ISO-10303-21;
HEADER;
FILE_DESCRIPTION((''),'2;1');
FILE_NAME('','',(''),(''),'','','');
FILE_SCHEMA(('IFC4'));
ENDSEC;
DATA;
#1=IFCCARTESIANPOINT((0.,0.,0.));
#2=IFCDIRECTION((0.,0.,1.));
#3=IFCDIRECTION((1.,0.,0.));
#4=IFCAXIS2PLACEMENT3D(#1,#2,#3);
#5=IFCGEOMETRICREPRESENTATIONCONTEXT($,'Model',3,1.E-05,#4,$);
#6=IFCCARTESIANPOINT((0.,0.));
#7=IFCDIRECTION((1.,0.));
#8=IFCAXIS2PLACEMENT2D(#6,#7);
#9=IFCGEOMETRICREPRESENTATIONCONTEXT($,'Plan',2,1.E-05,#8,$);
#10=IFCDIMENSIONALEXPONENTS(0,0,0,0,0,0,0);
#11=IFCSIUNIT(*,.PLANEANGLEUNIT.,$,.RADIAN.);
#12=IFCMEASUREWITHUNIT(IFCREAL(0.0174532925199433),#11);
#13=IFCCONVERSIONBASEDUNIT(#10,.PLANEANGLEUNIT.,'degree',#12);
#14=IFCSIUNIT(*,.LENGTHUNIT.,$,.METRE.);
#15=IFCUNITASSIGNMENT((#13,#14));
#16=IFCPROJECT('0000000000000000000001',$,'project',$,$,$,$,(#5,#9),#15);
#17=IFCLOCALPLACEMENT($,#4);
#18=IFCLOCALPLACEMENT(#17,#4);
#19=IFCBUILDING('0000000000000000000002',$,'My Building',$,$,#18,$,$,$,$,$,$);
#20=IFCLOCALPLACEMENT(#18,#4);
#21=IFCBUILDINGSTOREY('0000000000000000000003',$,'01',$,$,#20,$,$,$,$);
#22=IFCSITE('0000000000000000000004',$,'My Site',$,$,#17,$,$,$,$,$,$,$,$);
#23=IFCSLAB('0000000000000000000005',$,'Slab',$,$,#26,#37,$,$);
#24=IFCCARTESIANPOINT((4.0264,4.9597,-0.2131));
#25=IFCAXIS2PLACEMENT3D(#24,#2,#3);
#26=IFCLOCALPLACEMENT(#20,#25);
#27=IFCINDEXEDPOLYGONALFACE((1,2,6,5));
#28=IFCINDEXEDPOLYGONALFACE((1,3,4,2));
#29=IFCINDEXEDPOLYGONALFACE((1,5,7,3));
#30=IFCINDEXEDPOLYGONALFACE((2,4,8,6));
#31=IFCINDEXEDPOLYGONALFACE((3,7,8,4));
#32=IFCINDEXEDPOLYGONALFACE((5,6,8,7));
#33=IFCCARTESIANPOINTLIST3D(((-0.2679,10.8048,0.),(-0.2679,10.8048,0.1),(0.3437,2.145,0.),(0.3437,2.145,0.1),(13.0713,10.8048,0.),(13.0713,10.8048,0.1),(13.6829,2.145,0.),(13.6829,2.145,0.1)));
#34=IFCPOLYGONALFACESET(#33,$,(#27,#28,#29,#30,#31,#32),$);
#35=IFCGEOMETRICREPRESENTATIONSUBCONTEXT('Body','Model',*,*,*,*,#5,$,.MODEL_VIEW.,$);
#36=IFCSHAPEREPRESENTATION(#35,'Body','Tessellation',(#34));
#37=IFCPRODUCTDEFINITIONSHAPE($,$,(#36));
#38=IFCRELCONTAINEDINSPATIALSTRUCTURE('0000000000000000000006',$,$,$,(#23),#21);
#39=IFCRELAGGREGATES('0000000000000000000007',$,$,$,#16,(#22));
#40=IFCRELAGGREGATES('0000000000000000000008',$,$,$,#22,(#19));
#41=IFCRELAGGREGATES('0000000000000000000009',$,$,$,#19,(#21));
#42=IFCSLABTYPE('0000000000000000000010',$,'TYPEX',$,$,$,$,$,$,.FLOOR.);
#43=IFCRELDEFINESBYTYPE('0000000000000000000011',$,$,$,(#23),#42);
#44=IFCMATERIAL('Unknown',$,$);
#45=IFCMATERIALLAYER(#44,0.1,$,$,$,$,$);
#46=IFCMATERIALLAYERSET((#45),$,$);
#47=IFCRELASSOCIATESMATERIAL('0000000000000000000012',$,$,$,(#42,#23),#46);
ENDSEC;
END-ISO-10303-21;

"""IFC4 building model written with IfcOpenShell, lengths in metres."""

from ifc_helpers import new_model, entity, si_unit, converted_unit, frame, origin_with_axes, origin_2d_with_axis, place, context, subcontext, project, spatial, line, indexed_curve, outline, extrude, material, layer, layer_set, layer_usage, type_object, element, save


model = new_model("IFC4")

# Units and contexts
model_context = context("Model", 3, precision=1e-05, world=origin_with_axes())
plan_context = context("Plan", 2, precision=1e-05, world=origin_2d_with_axis())
body_context = subcontext(model_context, "Body", "Model", "MODEL_VIEW")
ifc_project = project(units=[converted_unit("PLANEANGLEUNIT", "degree", entity("IfcReal", 0.0174532925199433), si_unit("PLANEANGLEUNIT", "RADIAN"), dimensions=[0, 0, 0, 0, 0, 0, 0]), si_unit("LENGTHUNIT", "METRE")], contexts=[model_context, plan_context])

# Site, building, storey
site_placement = place(None, origin_with_axes())
site = spatial("IfcSite", under=ifc_project, at=site_placement, Name="My Site")
building_placement = place(site_placement, origin_with_axes())
building = spatial("IfcBuilding", under=site, at=building_placement, Name="My Building")
storey_placement = place(building_placement, origin_with_axes())
storey = spatial("IfcBuildingStorey", under=building, at=storey_placement, Name="01")

# Slab
ifc_material = material(Name="Unknown")
ifc_layer_1 = layer(ifc_material, 0.1)
ifc_layer_set_1 = layer_set([ifc_layer_1])
ifc_layer_usage_1 = layer_usage(ifc_layer_set_1, "AXIS3", "POSITIVE", 0.0)
slab_type = type_object("IfcSlabType", Name="TYPEX", PredefinedType="FLOOR", material=ifc_layer_set_1)
slab_placement = place(storey_placement, frame((4.0264, 4.9597, -0.2131), z_axis=(0.0, 0.0, 1.0), x_axis=(1.0, 0.0, 0.0)))
element("IfcSlab", 1, at=slab_placement, inside=storey, type_object=slab_type, material=ifc_layer_usage_1, Name="Slab", context=body_context, shape_type="SweptSolid", body=[
    extrude(outline(indexed_curve([(-0.2679, 10.8048), (13.0713, 10.8048), (13.6829, 2.145), (0.3437, 2.145)], segments=[line(3, 2), line(2, 1), line(1, 4), line(4, 3)], self_intersect=False)), None, (0.0, 0.0, 1.0), 0.1),
])

save(model, "model.ifc")
